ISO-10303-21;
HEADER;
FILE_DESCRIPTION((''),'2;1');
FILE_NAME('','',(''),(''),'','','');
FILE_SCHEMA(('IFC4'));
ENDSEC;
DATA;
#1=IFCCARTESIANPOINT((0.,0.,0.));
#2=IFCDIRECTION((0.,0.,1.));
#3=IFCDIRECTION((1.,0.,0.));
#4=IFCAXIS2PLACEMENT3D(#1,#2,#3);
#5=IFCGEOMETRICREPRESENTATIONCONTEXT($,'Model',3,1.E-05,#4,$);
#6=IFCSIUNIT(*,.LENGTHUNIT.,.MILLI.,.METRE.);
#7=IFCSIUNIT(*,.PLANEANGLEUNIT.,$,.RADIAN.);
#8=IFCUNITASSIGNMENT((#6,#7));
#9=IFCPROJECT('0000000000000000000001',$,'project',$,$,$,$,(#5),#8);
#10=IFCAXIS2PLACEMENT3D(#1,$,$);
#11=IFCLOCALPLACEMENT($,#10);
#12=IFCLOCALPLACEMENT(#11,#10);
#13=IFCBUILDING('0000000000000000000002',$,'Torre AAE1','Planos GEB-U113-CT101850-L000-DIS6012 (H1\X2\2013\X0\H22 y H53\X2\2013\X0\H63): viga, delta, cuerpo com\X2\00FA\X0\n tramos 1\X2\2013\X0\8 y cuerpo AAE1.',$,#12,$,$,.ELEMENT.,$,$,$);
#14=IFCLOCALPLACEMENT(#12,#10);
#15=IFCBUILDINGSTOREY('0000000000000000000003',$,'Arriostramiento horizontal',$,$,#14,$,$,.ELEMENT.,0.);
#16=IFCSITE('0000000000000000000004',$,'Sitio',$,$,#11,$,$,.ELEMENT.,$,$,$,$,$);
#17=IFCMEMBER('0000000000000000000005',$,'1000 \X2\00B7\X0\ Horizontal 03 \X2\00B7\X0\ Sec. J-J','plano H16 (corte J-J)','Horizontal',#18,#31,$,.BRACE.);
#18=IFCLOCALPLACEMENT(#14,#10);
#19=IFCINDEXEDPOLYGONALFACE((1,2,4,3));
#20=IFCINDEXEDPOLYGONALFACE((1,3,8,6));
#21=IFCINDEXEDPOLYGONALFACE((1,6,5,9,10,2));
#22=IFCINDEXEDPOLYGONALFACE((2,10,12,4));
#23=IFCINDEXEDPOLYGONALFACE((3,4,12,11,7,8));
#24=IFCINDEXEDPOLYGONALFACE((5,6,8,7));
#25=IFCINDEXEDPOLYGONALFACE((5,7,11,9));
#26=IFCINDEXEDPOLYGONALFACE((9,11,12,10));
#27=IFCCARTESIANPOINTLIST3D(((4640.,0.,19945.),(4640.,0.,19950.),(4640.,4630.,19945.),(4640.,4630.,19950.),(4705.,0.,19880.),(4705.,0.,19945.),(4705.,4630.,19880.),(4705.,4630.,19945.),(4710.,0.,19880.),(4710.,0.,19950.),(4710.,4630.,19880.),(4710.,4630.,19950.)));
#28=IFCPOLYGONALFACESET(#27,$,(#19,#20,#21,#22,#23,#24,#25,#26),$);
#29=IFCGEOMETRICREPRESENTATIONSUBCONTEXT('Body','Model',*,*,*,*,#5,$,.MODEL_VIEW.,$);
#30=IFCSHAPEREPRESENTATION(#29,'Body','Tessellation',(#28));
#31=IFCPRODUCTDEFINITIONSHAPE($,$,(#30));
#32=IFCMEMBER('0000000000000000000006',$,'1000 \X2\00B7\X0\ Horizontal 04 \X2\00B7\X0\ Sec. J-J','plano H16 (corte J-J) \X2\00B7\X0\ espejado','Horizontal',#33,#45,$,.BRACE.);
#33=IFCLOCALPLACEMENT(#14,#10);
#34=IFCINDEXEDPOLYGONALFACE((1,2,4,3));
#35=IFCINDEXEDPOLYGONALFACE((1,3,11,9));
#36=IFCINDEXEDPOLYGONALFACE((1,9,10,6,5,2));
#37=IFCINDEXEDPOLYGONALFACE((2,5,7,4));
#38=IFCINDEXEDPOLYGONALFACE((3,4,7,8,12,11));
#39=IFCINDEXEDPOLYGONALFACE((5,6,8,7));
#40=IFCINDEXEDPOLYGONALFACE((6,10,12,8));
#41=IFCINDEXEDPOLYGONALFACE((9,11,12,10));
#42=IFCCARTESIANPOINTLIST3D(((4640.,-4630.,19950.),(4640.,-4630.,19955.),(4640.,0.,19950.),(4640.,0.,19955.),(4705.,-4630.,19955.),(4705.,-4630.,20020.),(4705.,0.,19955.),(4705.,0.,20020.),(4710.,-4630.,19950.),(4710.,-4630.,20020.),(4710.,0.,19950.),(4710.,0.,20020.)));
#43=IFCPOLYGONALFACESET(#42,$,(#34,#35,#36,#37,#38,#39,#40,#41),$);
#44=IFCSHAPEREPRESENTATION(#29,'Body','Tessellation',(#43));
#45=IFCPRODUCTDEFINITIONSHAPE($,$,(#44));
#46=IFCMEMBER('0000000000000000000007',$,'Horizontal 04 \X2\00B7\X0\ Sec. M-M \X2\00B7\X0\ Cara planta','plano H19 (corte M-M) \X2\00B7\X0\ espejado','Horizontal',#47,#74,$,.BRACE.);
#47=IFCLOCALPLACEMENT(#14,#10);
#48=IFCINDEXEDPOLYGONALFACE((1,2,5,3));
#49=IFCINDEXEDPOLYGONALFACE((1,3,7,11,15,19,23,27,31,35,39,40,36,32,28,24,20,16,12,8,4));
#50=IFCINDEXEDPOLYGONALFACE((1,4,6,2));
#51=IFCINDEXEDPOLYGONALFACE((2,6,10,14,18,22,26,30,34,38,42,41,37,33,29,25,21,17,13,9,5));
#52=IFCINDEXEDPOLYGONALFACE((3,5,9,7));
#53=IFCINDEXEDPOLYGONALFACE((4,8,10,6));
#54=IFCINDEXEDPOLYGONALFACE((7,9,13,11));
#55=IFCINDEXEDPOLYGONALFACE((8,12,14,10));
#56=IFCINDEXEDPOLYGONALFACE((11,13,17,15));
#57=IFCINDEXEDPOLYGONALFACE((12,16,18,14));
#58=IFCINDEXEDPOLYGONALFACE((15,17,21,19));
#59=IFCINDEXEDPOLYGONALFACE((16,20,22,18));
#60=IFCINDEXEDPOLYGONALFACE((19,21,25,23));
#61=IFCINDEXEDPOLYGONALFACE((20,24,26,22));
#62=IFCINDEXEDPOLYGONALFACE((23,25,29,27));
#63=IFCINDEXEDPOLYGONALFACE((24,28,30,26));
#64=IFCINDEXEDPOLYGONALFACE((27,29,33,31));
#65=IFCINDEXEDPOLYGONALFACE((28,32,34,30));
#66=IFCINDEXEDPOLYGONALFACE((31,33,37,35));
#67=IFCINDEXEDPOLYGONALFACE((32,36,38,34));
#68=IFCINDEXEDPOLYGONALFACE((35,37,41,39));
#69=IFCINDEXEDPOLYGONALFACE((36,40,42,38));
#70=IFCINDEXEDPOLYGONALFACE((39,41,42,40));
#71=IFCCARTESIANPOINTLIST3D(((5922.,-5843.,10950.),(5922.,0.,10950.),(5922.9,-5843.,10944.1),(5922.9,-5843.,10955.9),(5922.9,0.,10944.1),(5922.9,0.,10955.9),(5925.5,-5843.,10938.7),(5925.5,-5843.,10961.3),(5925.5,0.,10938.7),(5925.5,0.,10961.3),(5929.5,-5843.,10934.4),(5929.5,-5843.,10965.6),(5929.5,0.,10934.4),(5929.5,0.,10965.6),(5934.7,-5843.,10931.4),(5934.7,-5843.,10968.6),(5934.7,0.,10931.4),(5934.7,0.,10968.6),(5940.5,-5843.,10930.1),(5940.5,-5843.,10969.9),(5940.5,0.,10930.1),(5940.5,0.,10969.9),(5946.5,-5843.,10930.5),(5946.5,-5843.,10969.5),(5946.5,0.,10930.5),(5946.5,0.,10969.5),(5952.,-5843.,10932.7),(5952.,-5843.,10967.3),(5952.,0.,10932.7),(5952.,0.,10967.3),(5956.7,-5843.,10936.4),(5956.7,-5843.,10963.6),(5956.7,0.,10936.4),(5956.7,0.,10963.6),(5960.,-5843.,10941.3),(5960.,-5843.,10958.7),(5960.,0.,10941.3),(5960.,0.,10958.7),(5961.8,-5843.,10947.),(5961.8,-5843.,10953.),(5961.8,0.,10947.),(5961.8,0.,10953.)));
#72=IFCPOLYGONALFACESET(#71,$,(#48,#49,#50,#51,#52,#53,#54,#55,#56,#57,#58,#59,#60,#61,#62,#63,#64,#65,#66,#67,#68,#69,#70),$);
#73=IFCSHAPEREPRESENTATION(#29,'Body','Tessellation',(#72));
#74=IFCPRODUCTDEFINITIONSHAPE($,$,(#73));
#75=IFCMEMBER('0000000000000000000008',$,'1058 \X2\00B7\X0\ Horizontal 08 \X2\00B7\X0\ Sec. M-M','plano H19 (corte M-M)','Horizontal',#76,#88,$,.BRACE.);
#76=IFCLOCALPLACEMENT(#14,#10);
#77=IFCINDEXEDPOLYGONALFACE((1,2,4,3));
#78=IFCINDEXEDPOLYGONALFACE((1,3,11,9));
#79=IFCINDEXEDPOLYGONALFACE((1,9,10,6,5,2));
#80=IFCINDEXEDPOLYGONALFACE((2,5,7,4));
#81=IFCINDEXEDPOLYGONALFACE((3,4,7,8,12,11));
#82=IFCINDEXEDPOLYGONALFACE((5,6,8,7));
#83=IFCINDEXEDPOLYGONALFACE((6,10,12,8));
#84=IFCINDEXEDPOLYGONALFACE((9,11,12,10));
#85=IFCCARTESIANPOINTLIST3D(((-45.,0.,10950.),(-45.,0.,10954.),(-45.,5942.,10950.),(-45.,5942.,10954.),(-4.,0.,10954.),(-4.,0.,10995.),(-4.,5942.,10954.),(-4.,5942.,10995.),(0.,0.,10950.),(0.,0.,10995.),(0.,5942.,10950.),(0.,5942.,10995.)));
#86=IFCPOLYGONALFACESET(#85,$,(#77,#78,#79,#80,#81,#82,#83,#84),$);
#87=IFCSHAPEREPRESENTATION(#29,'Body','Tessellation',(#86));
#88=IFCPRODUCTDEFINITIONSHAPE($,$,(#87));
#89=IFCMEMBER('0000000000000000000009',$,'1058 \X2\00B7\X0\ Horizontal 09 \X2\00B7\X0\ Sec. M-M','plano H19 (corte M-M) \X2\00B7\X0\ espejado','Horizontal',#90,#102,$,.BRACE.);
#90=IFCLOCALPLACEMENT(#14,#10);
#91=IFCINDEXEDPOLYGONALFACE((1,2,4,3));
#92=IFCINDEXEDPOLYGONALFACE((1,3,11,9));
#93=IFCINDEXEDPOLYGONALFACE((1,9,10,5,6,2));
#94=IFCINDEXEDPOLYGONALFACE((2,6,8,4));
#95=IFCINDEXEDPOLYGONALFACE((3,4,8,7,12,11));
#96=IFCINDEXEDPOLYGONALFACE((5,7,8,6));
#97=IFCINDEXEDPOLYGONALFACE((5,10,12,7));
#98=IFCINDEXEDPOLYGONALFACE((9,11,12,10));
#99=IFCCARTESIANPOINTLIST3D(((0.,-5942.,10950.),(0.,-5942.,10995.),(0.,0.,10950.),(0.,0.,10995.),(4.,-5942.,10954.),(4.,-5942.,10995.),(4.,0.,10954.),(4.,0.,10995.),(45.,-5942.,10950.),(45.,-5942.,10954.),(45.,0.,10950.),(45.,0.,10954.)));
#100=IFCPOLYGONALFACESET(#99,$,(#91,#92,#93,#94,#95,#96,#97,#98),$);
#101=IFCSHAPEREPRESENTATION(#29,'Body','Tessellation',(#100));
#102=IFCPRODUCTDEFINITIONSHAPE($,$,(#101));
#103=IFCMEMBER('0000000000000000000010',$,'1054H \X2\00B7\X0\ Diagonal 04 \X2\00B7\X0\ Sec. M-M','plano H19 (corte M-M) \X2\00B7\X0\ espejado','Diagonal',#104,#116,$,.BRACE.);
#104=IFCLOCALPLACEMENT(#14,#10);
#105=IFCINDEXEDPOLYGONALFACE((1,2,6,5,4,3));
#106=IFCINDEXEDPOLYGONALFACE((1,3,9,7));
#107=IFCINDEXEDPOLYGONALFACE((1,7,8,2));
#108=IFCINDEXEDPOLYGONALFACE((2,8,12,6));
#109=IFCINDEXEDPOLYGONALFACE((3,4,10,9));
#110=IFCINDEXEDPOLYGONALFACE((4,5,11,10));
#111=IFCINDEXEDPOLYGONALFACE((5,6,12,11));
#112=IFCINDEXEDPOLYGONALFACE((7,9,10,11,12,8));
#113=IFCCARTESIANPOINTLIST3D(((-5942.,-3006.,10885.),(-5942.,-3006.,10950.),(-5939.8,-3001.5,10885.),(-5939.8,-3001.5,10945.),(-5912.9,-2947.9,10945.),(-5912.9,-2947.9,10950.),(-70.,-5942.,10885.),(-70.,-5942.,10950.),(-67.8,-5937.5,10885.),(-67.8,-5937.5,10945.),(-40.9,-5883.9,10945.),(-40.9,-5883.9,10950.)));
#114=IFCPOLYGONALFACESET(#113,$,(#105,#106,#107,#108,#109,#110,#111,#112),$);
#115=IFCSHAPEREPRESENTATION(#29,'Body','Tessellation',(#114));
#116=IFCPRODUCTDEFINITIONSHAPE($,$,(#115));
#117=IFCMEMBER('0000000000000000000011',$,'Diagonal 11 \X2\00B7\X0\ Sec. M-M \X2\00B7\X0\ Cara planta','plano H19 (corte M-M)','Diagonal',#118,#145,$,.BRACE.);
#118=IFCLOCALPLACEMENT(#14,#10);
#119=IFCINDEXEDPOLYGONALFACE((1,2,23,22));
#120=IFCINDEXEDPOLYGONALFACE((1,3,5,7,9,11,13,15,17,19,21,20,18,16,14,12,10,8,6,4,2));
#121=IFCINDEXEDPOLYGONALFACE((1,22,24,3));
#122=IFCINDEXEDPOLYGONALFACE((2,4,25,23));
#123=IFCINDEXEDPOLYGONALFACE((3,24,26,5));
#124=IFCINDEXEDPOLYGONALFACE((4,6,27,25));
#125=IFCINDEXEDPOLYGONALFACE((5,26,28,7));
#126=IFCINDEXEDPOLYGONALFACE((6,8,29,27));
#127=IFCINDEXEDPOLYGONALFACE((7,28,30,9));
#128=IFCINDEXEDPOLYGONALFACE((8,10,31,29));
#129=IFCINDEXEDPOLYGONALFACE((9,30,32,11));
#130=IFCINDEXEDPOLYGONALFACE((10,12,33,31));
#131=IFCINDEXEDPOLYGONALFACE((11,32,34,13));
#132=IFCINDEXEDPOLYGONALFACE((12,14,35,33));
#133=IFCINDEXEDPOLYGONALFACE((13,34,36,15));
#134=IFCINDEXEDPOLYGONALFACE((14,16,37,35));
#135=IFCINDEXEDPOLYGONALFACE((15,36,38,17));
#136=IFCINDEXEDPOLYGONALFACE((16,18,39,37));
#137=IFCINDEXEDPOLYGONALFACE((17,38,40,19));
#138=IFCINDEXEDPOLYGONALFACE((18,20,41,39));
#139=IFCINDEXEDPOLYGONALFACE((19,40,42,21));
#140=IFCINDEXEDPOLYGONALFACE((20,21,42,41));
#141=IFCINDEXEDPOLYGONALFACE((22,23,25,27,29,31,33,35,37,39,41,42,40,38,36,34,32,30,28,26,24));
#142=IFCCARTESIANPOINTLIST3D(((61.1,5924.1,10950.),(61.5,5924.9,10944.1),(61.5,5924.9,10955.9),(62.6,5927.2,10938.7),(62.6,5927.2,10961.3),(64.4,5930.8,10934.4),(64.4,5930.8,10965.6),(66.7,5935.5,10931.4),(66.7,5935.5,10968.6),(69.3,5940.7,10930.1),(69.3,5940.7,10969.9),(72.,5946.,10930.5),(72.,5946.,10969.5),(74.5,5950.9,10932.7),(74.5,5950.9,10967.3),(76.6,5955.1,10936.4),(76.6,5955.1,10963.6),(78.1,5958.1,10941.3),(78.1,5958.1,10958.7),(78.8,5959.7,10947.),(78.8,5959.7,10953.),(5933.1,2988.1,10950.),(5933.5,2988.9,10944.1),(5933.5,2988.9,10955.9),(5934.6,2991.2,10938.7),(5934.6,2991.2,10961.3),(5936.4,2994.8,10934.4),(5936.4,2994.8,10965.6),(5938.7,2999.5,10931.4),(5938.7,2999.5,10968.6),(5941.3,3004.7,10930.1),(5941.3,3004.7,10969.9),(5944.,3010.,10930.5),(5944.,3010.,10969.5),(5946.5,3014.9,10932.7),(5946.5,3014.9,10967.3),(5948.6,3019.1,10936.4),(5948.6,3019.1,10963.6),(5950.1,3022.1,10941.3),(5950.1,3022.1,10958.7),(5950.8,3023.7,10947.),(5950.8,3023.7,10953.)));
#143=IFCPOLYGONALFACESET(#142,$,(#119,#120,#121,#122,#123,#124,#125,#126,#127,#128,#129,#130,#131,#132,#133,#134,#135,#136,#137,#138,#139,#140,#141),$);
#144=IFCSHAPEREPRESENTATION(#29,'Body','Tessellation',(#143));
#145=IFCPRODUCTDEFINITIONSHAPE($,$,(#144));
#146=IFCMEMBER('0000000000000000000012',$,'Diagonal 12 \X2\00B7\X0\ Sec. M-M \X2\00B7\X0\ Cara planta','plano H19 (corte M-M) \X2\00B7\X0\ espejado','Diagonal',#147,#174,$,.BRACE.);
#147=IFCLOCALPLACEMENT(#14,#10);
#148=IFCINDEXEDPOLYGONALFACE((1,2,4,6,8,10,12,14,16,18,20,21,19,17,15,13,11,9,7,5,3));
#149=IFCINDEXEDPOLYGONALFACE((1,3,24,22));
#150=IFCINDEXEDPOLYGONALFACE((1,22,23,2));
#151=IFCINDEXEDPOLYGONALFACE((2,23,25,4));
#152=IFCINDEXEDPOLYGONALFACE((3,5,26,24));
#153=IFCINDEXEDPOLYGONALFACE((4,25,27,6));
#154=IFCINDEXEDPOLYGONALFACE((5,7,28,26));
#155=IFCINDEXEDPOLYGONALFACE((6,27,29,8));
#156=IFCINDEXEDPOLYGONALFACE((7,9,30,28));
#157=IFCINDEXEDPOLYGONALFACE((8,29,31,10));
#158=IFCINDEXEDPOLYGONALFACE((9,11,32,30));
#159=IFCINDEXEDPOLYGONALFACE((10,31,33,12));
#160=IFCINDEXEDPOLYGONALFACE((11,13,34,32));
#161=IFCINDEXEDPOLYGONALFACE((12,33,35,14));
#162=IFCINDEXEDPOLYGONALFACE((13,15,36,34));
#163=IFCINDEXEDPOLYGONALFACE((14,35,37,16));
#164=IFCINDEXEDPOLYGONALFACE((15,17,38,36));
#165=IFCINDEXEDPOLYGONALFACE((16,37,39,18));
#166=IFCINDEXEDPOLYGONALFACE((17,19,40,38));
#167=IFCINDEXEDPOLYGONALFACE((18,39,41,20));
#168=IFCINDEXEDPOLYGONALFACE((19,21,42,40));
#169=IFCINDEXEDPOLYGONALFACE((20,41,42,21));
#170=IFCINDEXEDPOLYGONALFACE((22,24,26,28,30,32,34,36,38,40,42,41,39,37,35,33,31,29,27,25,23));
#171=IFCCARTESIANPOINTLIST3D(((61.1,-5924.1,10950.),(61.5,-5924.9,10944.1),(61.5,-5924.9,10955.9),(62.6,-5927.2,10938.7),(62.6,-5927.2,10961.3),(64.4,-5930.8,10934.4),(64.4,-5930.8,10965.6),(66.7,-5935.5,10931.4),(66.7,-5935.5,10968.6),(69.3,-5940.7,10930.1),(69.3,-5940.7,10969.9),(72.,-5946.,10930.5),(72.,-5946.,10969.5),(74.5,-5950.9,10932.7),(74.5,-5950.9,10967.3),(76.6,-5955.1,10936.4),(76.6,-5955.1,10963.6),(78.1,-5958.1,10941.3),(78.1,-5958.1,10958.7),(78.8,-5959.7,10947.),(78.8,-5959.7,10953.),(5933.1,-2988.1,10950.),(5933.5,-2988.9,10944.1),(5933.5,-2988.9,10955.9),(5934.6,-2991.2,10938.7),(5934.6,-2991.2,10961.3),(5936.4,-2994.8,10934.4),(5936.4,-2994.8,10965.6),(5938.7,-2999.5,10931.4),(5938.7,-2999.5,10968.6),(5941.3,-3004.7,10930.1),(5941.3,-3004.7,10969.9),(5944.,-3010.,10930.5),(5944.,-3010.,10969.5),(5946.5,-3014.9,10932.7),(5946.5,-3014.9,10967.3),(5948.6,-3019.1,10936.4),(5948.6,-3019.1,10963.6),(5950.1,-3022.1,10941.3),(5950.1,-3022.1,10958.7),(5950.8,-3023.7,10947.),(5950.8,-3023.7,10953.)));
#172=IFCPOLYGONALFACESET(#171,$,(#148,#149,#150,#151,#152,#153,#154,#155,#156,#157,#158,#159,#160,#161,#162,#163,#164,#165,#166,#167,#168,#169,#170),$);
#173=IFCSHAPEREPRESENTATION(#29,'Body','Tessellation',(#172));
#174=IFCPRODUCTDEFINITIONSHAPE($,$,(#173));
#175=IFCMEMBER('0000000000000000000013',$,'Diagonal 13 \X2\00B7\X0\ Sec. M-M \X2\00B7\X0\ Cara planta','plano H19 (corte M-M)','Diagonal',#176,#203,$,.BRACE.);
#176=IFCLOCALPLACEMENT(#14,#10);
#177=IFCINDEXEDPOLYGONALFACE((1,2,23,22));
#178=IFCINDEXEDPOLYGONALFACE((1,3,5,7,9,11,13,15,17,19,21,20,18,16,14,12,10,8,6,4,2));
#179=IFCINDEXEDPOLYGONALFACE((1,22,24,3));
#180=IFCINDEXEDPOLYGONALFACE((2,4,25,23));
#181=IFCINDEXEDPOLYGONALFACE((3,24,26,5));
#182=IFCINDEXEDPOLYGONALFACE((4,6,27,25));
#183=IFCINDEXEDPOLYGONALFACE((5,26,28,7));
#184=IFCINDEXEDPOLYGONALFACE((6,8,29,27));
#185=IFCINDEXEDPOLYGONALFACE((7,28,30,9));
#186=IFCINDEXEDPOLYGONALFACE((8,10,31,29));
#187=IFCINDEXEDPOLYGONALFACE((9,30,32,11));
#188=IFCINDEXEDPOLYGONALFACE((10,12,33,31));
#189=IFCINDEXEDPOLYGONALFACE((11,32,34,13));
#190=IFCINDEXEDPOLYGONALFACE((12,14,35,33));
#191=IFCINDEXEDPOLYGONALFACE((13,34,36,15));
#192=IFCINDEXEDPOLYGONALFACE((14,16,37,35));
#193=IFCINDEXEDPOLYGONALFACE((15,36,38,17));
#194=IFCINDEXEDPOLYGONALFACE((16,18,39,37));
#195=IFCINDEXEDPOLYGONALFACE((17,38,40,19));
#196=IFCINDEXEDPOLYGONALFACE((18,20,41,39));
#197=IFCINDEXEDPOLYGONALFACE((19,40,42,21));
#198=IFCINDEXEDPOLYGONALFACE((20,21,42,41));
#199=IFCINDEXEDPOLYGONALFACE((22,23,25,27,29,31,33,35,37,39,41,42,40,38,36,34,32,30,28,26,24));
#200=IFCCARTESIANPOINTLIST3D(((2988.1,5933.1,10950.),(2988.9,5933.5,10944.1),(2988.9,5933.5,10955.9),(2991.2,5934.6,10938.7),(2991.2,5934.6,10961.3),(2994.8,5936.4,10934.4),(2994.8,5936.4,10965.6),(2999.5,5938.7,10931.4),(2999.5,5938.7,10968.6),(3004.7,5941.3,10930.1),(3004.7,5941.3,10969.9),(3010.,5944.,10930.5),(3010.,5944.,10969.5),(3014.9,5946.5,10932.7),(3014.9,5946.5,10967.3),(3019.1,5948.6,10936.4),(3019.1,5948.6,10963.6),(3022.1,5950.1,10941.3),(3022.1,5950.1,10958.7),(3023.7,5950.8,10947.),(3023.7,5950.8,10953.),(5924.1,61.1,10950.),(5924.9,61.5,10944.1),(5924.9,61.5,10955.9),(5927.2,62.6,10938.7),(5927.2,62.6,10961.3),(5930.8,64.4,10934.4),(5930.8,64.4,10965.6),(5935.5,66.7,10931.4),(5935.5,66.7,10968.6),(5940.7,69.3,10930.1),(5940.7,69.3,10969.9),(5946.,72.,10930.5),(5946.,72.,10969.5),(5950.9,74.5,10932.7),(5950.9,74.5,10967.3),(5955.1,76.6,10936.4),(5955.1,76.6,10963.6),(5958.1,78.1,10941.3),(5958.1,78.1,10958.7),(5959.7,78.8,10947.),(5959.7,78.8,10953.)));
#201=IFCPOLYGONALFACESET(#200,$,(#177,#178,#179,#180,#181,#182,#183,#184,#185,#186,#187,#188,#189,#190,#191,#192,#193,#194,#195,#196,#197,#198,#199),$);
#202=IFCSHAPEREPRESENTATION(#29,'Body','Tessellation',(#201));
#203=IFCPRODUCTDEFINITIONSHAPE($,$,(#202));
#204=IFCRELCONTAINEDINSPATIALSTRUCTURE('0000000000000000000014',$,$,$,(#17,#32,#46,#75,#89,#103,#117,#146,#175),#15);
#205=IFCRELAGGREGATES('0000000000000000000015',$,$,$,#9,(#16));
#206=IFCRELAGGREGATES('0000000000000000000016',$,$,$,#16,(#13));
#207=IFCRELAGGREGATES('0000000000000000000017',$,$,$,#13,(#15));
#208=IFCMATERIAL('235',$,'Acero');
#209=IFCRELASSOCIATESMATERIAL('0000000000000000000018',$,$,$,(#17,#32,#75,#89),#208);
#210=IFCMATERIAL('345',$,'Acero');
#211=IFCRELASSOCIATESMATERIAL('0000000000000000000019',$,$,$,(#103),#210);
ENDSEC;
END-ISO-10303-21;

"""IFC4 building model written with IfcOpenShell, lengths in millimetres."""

from ifc_helpers import new_model, si_unit, frame, frame_2d, origin, origin_with_axes, place, context, subcontext, project, spatial, circle, l_section, extrude, material, element, save


model = new_model("IFC4")

# Units and contexts
model_context = context("Model", 3, precision=1e-05, world=origin_with_axes())
body_context = subcontext(model_context, "Body", "Model", "MODEL_VIEW")
ifc_project = project(units=[si_unit("LENGTHUNIT", "METRE", prefix="MILLI"), si_unit("PLANEANGLEUNIT", "RADIAN")], contexts=[model_context])

# Site, building, storey
site_placement = place(None, origin())
site = spatial("IfcSite", under=ifc_project, at=site_placement, Name="Sitio", CompositionType="ELEMENT")
building_placement = place(site_placement, origin())
building = spatial("IfcBuilding", under=site, at=building_placement, Name="Torre AAE1", Description="Planos GEB-U113-CT101850-L000-DIS6012 (H1–H22 y H53–H63): viga, delta, cuerpo común tramos 1–8 y cuerpo AAE1.", CompositionType="ELEMENT")
storey_placement = place(building_placement, origin())
storey = spatial("IfcBuildingStorey", under=building, at=storey_placement, Name="Arriostramiento horizontal", CompositionType="ELEMENT", Elevation=0.0)

# Members
ifc_material_1 = material(Name="235", Category="Acero")
for number, where, z_axis, x_axis, name, description in (
    (1, (4710.0, 4630.0, 19950.0), (0.0, -1.0, 0.0), (-1.0, 0.0, 0.0), "1000 · Horizontal 03 · Sec. J-J", "plano H16 (corte J-J)"),
    (2, (4710.0, -4630.0, 19950.0), (0.0, 1.0, 0.0), (-1.0, 0.0, 0.0), "1000 · Horizontal 04 · Sec. J-J", "plano H16 (corte J-J) · espejado"),
):
    element("IfcMember", number, at=place(storey_placement, frame(where, z_axis=z_axis, x_axis=x_axis)), inside=storey, material=ifc_material_1, Name=name, Description=description, ObjectType="Horizontal", PredefinedType="BRACE", context=body_context, shape_type="SweptSolid", body=[
        extrude(l_section(Depth=70.0, Width=70.0, Thickness=5.0, at=frame_2d((35.0, 35.0))), None, (0.0, 0.0, 1.0), 4630.0),
    ])
member_1_placement = place(storey_placement, frame((5942.0, -5843.0, 10950.0), z_axis=(0.0, 1.0, 0.0), x_axis=(-1.0, 0.0, 0.0)))
element("IfcMember", 3, at=member_1_placement, inside=storey, Name="Horizontal 04 · Sec. M-M · Cara planta", Description="plano H19 (corte M-M) · espejado", ObjectType="Horizontal", PredefinedType="BRACE", context=body_context, shape_type="SweptSolid", body=[
    extrude(circle(Radius=20.0), None, (0.0, 0.0, 1.0), 5843.0),
])
for number, where, z_axis, x_axis, name, description in (
    (4, (0.0, 5942.0, 10950.0), (0.0, -1.0, 0.0), (0.0, 0.0, 1.0), "1058 · Horizontal 08 · Sec. M-M", "plano H19 (corte M-M)"),
    (5, (0.0, -5942.0, 10950.0), (0.0, 1.0, 0.0), (0.0, 0.0, 1.0), "1058 · Horizontal 09 · Sec. M-M", "plano H19 (corte M-M) · espejado"),
):
    element("IfcMember", number, at=place(storey_placement, frame(where, z_axis=z_axis, x_axis=x_axis)), inside=storey, material=ifc_material_1, Name=name, Description=description, ObjectType="Horizontal", PredefinedType="BRACE", context=body_context, shape_type="SweptSolid", body=[
        extrude(l_section(Depth=45.0, Width=45.0, Thickness=4.0, at=frame_2d((22.5, 22.5))), None, (0.0, 0.0, 1.0), 5942.0),
    ])
ifc_material_2 = material(Name="345", Category="Acero")
member_2_placement = place(storey_placement, frame((-70.0, -5942.0, 10950.0), z_axis=(-0.894427, 0.447214, 0.0), x_axis=(0.447214, 0.894427, 0.0)))
element("IfcMember", 6, at=member_2_placement, inside=storey, material=ifc_material_2, Name="1054H · Diagonal 04 · Sec. M-M", Description="plano H19 (corte M-M) · espejado", ObjectType="Diagonal", PredefinedType="BRACE", context=body_context, shape_type="SweptSolid", body=[
    extrude(l_section(Depth=65.0, Width=65.0, Thickness=5.0, at=frame_2d((32.5, 32.5))), None, (0.0, 0.0, 1.0), 6565.1),
])
for number, where, z_axis, x_axis, name, description in (
    (7, (70.0, 5942.0, 10950.0), (0.894427, -0.447214, 0.0), (-0.447214, -0.894427, 0.0), "Diagonal 11 · Sec. M-M · Cara planta", "plano H19 (corte M-M)"),
    (8, (70.0, -5942.0, 10950.0), (0.894427, 0.447214, 0.0), (-0.447214, 0.894427, 0.0), "Diagonal 12 · Sec. M-M · Cara planta", "plano H19 (corte M-M) · espejado"),
    (9, (5942.0, 70.0, 10950.0), (-0.447214, 0.894427, 0.0), (-0.894427, -0.447214, 0.0), "Diagonal 13 · Sec. M-M · Cara planta", "plano H19 (corte M-M)"),
):
    element("IfcMember", number, at=place(storey_placement, frame(where, z_axis=z_axis, x_axis=x_axis)), inside=storey, Name=name, Description=description, ObjectType="Diagonal", PredefinedType="BRACE", context=body_context, shape_type="SweptSolid", body=[
        extrude(circle(Radius=20.0), None, (0.0, 0.0, 1.0), 6565.1),
    ])

save(model, "model.ifc")
